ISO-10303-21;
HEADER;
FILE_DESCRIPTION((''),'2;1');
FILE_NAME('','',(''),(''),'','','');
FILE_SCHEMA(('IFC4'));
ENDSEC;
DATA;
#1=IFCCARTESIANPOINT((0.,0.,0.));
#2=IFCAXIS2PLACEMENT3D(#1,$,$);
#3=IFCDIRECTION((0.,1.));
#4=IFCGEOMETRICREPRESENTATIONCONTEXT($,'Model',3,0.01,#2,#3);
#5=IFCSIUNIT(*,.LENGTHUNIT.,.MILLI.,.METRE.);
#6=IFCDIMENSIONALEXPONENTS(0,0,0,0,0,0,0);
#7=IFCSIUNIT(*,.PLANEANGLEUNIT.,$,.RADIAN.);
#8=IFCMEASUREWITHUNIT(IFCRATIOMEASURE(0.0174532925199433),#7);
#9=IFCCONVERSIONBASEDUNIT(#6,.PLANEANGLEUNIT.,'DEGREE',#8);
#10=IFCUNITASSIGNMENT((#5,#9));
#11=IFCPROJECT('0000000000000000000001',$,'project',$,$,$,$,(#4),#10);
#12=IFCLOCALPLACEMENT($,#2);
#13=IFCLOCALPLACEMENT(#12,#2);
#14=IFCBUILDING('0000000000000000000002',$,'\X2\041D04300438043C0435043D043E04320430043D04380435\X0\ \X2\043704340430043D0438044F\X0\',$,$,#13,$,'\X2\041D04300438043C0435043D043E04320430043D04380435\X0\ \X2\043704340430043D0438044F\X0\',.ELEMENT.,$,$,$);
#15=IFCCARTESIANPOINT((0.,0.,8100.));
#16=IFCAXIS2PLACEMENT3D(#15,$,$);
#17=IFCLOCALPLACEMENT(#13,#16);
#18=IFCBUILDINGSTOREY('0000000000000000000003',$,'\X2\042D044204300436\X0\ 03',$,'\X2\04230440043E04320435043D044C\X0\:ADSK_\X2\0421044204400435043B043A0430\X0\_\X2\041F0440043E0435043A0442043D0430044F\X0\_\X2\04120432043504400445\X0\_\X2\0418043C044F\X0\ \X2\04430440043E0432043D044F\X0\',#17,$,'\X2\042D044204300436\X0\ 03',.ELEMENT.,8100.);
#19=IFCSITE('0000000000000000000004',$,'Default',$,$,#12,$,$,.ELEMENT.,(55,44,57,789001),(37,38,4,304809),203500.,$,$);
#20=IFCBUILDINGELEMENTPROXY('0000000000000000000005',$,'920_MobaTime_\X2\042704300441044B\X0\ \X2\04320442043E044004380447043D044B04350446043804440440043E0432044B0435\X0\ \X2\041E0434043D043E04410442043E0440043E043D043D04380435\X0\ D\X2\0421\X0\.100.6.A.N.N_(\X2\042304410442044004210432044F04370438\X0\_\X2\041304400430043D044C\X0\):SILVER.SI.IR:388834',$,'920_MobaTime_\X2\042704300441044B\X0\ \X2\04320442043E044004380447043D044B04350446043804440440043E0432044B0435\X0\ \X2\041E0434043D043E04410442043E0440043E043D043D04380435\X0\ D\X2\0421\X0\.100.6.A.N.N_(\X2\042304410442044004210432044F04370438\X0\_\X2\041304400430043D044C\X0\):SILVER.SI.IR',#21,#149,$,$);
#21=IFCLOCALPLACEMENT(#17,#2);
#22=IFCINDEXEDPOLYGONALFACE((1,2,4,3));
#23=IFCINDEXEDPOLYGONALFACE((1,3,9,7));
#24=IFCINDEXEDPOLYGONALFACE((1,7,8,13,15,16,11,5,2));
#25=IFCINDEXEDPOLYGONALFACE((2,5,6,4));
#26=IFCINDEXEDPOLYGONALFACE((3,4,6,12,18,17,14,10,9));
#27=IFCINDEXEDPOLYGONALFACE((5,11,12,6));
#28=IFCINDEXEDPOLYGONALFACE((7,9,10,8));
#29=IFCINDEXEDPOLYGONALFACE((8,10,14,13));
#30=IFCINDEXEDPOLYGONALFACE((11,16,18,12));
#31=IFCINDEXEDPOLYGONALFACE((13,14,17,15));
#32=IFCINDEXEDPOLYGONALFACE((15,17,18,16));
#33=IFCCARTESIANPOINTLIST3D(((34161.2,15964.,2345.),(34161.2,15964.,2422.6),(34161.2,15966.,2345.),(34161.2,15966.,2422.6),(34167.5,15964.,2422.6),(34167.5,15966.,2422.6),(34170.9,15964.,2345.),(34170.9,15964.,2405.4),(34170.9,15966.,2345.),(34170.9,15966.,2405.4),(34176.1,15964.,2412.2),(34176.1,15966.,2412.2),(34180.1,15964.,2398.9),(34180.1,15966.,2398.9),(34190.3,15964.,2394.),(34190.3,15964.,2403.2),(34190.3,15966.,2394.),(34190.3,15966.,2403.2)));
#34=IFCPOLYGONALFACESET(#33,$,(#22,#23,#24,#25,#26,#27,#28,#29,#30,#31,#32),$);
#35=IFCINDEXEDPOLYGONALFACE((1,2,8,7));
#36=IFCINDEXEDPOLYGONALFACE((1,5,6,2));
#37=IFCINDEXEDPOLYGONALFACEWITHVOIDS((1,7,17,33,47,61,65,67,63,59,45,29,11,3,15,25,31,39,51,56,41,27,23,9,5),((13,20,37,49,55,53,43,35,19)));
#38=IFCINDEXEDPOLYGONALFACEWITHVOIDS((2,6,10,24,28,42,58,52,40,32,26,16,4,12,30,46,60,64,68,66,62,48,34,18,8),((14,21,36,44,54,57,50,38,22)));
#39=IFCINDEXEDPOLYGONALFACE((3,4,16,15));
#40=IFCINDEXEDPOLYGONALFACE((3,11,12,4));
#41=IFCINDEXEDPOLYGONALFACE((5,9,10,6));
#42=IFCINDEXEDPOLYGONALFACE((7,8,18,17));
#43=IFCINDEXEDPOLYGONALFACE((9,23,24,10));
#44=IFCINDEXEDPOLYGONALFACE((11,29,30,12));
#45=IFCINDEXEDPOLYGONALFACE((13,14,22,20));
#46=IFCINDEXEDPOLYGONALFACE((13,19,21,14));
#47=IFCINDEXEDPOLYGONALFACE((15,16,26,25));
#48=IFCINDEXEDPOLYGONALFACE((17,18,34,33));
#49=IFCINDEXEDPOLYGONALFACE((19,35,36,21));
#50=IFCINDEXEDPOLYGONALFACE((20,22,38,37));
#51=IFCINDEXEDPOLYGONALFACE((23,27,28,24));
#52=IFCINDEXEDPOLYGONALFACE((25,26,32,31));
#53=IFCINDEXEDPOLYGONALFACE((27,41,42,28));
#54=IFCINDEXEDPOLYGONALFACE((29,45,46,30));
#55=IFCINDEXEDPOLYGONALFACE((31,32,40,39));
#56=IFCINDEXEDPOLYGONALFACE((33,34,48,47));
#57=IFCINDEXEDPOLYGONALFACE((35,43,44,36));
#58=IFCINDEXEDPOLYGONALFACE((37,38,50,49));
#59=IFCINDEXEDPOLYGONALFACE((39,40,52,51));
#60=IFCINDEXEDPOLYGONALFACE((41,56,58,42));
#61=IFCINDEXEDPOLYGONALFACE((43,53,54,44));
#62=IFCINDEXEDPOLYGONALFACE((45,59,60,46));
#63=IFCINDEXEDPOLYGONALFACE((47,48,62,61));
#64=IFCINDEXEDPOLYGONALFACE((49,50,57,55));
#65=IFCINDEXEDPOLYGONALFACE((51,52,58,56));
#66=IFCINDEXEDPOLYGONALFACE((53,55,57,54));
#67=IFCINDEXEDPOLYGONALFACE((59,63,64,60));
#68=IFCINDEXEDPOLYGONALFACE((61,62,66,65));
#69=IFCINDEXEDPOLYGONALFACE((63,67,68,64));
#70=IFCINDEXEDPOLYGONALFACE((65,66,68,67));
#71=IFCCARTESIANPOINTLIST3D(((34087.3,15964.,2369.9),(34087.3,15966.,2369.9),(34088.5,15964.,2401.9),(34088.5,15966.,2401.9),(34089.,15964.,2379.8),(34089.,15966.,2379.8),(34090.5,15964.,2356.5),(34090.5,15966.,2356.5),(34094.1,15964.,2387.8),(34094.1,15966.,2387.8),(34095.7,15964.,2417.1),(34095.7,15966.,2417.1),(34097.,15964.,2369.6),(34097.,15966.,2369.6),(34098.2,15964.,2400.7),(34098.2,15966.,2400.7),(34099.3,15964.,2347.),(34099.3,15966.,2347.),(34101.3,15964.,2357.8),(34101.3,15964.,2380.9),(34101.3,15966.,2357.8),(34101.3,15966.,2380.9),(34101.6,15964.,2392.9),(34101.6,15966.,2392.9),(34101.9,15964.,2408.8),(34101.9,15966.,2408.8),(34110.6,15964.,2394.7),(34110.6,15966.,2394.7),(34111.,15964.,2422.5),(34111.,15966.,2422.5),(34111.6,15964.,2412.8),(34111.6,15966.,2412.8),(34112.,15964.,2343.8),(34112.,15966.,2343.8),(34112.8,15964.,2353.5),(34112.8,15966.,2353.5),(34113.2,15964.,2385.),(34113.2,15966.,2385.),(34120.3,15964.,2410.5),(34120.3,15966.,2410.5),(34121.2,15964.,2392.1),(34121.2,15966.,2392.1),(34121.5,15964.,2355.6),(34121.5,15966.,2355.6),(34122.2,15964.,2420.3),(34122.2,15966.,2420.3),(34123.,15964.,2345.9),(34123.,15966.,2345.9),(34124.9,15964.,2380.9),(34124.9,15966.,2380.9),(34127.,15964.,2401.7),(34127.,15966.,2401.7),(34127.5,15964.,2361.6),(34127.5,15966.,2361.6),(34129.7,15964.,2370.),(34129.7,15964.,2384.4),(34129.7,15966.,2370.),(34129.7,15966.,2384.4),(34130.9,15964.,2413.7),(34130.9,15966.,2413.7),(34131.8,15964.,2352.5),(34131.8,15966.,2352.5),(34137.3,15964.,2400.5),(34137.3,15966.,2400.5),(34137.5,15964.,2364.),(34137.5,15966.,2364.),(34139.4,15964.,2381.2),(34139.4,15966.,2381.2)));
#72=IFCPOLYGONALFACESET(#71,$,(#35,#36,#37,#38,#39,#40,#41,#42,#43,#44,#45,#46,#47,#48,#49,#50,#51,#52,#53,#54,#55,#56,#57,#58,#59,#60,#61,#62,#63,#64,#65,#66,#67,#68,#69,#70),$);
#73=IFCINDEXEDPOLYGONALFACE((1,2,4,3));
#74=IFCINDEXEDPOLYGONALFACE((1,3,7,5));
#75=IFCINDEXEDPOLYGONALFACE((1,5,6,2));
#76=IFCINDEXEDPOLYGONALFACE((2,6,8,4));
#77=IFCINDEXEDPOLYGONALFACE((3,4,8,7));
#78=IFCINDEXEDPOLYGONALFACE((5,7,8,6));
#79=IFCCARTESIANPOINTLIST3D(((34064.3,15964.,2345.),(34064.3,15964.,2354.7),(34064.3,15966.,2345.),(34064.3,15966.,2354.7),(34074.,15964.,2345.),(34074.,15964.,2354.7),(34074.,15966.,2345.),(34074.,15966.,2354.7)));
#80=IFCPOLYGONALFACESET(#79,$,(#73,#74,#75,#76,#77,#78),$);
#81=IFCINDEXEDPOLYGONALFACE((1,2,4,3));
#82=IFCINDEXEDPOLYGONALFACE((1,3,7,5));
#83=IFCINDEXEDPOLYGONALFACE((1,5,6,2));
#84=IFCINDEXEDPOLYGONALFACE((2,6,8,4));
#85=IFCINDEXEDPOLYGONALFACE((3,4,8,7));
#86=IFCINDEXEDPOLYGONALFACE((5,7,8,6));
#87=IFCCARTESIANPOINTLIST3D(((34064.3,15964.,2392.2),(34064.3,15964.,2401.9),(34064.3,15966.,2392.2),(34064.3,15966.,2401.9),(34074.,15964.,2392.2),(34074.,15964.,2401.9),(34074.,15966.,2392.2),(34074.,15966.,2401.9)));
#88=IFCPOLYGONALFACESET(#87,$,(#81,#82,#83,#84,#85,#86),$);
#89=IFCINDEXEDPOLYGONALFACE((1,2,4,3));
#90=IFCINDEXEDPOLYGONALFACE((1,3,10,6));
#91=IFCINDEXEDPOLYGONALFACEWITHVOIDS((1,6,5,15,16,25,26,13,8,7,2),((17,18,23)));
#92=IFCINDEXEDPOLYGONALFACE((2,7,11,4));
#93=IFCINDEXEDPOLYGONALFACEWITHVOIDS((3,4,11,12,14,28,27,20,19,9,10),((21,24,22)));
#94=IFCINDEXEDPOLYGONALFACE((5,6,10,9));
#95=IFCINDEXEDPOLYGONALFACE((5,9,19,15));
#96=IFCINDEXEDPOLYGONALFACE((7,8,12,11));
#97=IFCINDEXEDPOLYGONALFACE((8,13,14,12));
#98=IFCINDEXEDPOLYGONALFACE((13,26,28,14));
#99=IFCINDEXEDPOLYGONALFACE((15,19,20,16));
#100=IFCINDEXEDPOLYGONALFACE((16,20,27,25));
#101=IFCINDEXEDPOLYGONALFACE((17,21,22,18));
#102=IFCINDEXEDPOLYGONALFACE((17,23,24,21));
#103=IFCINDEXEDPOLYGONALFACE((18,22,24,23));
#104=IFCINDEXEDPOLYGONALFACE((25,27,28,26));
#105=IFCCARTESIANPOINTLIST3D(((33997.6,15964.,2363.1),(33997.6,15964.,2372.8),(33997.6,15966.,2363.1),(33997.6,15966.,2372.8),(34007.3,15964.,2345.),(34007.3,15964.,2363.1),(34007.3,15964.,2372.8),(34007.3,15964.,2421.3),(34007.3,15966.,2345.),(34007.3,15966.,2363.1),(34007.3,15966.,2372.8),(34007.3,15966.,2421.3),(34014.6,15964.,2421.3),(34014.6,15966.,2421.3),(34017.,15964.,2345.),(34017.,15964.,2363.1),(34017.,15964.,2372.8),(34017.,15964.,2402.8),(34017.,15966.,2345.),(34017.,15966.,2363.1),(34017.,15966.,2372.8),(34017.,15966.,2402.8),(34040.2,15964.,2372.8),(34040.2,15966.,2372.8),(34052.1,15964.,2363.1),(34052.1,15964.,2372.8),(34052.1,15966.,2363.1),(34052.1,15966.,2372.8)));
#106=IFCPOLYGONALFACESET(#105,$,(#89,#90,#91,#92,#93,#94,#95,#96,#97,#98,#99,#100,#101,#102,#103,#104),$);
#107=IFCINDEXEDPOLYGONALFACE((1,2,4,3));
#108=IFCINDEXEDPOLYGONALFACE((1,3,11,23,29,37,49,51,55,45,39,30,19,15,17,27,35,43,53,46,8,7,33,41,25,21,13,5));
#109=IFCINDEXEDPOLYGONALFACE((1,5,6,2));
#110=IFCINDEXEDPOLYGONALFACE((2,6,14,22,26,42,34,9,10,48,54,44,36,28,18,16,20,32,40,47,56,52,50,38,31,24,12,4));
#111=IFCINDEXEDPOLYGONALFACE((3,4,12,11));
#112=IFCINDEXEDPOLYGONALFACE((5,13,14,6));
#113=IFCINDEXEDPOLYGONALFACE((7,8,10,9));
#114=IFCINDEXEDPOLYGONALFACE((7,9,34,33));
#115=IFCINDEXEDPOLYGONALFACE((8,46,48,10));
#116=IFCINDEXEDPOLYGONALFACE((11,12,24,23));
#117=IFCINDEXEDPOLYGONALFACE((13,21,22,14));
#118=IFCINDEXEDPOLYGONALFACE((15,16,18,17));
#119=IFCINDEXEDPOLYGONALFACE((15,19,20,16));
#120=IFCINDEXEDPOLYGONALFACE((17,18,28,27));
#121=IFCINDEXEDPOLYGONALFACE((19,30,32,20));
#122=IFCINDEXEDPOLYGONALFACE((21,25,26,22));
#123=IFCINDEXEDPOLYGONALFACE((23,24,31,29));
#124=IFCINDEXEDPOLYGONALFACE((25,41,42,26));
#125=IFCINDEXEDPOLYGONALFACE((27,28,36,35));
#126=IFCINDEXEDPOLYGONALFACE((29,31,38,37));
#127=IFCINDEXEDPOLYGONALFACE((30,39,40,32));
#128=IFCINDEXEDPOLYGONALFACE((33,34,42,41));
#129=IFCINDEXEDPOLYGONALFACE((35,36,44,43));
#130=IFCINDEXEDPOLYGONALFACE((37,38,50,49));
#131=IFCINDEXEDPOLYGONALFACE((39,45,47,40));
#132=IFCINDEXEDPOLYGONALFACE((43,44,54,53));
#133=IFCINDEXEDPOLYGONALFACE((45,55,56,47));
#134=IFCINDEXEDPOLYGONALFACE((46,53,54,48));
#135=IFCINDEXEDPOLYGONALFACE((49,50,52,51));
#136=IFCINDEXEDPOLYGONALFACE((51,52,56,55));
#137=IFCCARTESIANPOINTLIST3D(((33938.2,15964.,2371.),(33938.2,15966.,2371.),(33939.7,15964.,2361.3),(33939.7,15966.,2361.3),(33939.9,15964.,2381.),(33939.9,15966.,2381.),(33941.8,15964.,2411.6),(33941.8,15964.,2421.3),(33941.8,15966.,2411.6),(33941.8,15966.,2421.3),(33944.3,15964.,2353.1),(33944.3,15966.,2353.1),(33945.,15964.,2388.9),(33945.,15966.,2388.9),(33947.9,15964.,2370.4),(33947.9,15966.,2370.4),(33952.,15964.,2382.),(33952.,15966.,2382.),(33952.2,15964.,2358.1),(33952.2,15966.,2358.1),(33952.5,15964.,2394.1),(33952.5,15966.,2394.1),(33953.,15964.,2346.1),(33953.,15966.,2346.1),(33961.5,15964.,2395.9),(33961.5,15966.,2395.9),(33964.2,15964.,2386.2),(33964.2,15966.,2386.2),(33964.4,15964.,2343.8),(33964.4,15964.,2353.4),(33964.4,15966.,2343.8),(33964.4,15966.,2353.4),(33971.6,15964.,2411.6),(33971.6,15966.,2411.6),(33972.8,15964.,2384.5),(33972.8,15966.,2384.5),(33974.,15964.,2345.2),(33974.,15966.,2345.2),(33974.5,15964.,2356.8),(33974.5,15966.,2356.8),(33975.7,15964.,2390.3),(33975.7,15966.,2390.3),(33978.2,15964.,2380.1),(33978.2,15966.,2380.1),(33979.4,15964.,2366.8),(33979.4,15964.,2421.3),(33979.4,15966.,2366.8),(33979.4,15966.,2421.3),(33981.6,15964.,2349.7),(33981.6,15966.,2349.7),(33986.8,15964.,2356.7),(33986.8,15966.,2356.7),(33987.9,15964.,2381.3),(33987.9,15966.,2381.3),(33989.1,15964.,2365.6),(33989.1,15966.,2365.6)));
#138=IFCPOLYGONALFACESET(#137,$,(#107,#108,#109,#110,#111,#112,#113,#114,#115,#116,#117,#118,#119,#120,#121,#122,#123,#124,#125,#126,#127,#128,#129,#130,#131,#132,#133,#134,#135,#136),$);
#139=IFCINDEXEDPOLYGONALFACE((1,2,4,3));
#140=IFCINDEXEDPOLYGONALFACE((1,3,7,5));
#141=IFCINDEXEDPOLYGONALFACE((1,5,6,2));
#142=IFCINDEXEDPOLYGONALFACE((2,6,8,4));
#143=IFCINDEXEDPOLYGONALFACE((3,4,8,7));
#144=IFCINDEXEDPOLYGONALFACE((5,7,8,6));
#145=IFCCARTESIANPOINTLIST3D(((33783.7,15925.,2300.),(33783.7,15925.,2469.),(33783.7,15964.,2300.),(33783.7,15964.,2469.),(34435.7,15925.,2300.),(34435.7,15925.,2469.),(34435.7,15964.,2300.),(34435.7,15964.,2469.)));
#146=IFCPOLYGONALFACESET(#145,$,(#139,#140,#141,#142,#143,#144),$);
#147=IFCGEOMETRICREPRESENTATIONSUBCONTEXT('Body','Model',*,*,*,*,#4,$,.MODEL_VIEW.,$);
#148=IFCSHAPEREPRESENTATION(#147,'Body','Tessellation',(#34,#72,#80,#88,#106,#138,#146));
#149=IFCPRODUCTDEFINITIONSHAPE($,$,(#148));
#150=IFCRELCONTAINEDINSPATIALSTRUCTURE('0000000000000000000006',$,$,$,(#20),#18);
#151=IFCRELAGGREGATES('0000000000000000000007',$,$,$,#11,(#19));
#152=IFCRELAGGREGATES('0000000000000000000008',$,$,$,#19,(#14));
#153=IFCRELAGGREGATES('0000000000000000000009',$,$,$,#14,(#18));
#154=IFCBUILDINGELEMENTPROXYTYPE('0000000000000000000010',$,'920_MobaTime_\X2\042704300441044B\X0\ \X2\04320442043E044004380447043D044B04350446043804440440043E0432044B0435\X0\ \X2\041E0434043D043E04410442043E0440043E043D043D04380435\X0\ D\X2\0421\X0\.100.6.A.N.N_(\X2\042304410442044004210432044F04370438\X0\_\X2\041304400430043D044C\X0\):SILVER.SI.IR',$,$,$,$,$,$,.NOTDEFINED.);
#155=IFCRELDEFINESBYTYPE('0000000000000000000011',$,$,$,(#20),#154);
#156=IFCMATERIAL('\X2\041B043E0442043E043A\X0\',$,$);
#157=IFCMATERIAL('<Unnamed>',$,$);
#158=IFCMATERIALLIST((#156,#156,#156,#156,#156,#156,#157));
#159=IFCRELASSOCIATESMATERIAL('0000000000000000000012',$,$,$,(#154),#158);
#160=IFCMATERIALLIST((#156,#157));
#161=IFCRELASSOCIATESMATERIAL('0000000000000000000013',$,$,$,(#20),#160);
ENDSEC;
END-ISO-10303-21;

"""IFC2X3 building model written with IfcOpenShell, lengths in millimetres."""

from ifc_helpers import new_model, entity, si_unit, converted_unit, direction, frame, origin, origin_2d_with_axis, place, context, subcontext, project, spatial, polyline, rectangle, outline, extrude, source, transform, mapped, material, material_list, type_object, type_shapes, element, save


model = new_model("IFC2X3")

# Units and contexts
model_context = context("Model", 3, precision=0.01, world=origin(), true_north=direction((0.0, 1.0)))
body_context = subcontext(model_context, "Body", "Model", "MODEL_VIEW")
ifc_project = project(units=[si_unit("LENGTHUNIT", "METRE", prefix="MILLI"), converted_unit("PLANEANGLEUNIT", "DEGREE", entity("IfcRatioMeasure", 0.0174532925199433), si_unit("PLANEANGLEUNIT", "RADIAN"), dimensions=[0, 0, 0, 0, 0, 0, 0])], contexts=[model_context])

# Site, building, storey
site_placement = place(None, origin())
site = spatial("IfcSite", under=ifc_project, at=site_placement, Name="Default", CompositionType="ELEMENT", RefLatitude=(55, 44, 57, 789001), RefLongitude=(37, 38, 4, 304809), RefElevation=203500.0)
building_placement = place(site_placement, origin())
building = spatial("IfcBuilding", under=site, at=building_placement, Name="Наименование здания", LongName="Наименование здания", CompositionType="ELEMENT")
storey_placement = place(building_placement, frame((0.0, 0.0, 8100.0)))
storey = spatial("IfcBuildingStorey", under=building, at=storey_placement, Name="Этаж 03", ObjectType="Уровень:ADSK_Стрелка_Проектная_Вверх_Имя уровня", LongName="Этаж 03", CompositionType="ELEMENT", Elevation=8100.0)

# Building element proxy
ifc_material_1 = material(Name="Лоток")
ifc_material_2 = material(Name="<Unnamed>")
ifc_material_list_1 = material_list([ifc_material_1, ifc_material_1, ifc_material_1, ifc_material_1, ifc_material_1, ifc_material_1, ifc_material_2])
building_element_proxy_type = type_object("IfcBuildingElementProxyType", Name="920_MobaTime_Часы вторичныецифровые Односторонние DС.100.6.A.N.N_(УстрСвязи_Грань):SILVER.SI.IR", PredefinedType="NOTDEFINED", material=ifc_material_list_1)
shared_shape = source(origin(), body_context, "Body", "SweptSolid", [
    extrude(outline(polyline([(-49.3, -13.1), (28.2, -13.1), (28.2, -6.8), (17.9, 1.8), (8.8, 16.0), (-0.3, 16.0), (4.6, 5.8), (11.1, -3.4), (-49.3, -3.4), (-49.3, -13.1)])), frame((-64.6, 9.8, 39.0), z_axis=(0.0, 0.0, 1.0), x_axis=(0.0, 1.0, 0.0)), (0.0, 0.0, 1.0), 2.0),
    extrude(outline(polyline([(2.2, -27.6), (19.0, -27.6), (30.5, -16.1), (33.3, -4.9), (31.0, 5.8), (21.8, 17.2), (5.2, 27.3), (-11.1, 33.0), (-24.0, 32.7), (-33.6, 27.6), (-40.3, 18.6), (-42.8, 5.7), (-38.0, -6.3), (-27.2, -14.9), (-17.5, -17.7), (-8.2, -16.4), (-0.3, -11.9), (5.1, -4.5), (7.3, 6.2), (4.0, 17.2), (18.4, 7.3), (23.6, -2.4), (22.0, -11.4), (14.2, -18.4), (5.3, -18.3), (2.2, -27.6)]), holes=[polyline([(-9.0, 23.3), (-1.3, 14.3), (-2.5, 2.0), (-11.4, -7.0), (-23.4, -6.0), (-32.2, 2.9), (-31.2, 15.1), (-25.6, 22.1), (-17.5, 24.9), (-9.0, 23.3)])]), frame((-2.7, 3.6, 39.0), z_axis=(0.0, 0.0, 1.0), x_axis=(-0.427649, 0.903945, 0.0)), (0.0, 0.0, 1.0), 2.0),
    extrude(rectangle(XDim=9.7, YDim=9.7, at=origin_2d_with_axis()), frame((40.6, -34.7, 39.0)), (0.0, 0.0, 1.0), 2.0),
    extrude(rectangle(XDim=9.7, YDim=9.7, at=origin_2d_with_axis()), frame((40.6, 12.6, 39.0)), (0.0, 0.0, 1.0), 2.0),
    extrude(outline(polyline([(-0.9, -28.1), (8.8, -28.1), (8.8, -9.9), (18.5, -9.9), (18.5, -0.2), (8.8, -0.2), (8.8, 48.3), (1.5, 48.3), (-36.0, -0.2), (-36.0, -9.9), (-0.9, -9.9), (-0.9, -28.1)]), holes=[polyline([(-0.9, -0.2), (-24.1, -0.2), (-0.9, 29.7), (-0.9, -0.2)])]), frame((93.6, -11.4, 39.0)), (0.0, 0.0, 1.0), 2.0),
    extrude(outline(polyline([(3.3, -28.3), (12.5, -28.3), (20.5, -25.0), (26.8, -18.9), (30.7, -10.0), (31.4, 1.6), (26.9, 11.8), (20.1, 18.4), (11.1, 22.3), (1.0, 23.3), (-7.9, 20.4), (-14.9, 14.5), (-18.9, 6.2), (-17.1, -9.0), (-36.7, 0.5), (-29.1, 29.2), (-38.5, 31.7), (-48.1, -4.6), (-11.6, -23.1), (-8.0, -14.0), (-10.8, -7.6), (-10.2, 1.1), (-3.0, 11.8), (9.2, 12.8), (20.0, 5.5), (21.4, -7.5), (15.5, -16.4), (4.6, -18.6), (3.3, -28.3)])), frame((147.1, -8.5, 39.0), z_axis=(0.0, 0.0, 1.0), x_axis=(0.256974, -0.966418, 0.0)), (0.0, 0.0, 1.0), 2.0),
    extrude(rectangle(XDim=652.0, YDim=169.0, at=origin_2d_with_axis()), frame((0.0, 0.0, 0.0), z_axis=(0.0, 0.0, 1.0), x_axis=(-1.0, 0.0, 0.0)), (0.0, 0.0, 1.0), 39.0),
])
type_shapes(building_element_proxy_type, [shared_shape])
ifc_material_list_2 = material_list([ifc_material_1, ifc_material_2])
for number, where, z_axis, x_axis, name in (
    (1, (34109.7, 15925.0, 2384.5), (0.0, 1.0, 0.0), (-1.0, 0.0, 0.0), "920_MobaTime_Часы вторичныецифровые Односторонние DС.100.6.A.N.N_(УстрСвязи_Грань):SILVER.SI.IR:388834"),
):
    element("IfcBuildingElementProxy", number, at=place(storey_placement, frame(where, z_axis=z_axis, x_axis=x_axis)), inside=storey, type_object=building_element_proxy_type, material=ifc_material_list_2, Name=name, ObjectType="920_MobaTime_Часы вторичныецифровые Односторонние DС.100.6.A.N.N_(УстрСвязи_Грань):SILVER.SI.IR", context=body_context, shape_type="MappedRepresentation", body=[
        mapped(shared_shape, transform((0.0, 0.0, 0.0), scale=1.0)),
    ])

save(model, "model.ifc")
